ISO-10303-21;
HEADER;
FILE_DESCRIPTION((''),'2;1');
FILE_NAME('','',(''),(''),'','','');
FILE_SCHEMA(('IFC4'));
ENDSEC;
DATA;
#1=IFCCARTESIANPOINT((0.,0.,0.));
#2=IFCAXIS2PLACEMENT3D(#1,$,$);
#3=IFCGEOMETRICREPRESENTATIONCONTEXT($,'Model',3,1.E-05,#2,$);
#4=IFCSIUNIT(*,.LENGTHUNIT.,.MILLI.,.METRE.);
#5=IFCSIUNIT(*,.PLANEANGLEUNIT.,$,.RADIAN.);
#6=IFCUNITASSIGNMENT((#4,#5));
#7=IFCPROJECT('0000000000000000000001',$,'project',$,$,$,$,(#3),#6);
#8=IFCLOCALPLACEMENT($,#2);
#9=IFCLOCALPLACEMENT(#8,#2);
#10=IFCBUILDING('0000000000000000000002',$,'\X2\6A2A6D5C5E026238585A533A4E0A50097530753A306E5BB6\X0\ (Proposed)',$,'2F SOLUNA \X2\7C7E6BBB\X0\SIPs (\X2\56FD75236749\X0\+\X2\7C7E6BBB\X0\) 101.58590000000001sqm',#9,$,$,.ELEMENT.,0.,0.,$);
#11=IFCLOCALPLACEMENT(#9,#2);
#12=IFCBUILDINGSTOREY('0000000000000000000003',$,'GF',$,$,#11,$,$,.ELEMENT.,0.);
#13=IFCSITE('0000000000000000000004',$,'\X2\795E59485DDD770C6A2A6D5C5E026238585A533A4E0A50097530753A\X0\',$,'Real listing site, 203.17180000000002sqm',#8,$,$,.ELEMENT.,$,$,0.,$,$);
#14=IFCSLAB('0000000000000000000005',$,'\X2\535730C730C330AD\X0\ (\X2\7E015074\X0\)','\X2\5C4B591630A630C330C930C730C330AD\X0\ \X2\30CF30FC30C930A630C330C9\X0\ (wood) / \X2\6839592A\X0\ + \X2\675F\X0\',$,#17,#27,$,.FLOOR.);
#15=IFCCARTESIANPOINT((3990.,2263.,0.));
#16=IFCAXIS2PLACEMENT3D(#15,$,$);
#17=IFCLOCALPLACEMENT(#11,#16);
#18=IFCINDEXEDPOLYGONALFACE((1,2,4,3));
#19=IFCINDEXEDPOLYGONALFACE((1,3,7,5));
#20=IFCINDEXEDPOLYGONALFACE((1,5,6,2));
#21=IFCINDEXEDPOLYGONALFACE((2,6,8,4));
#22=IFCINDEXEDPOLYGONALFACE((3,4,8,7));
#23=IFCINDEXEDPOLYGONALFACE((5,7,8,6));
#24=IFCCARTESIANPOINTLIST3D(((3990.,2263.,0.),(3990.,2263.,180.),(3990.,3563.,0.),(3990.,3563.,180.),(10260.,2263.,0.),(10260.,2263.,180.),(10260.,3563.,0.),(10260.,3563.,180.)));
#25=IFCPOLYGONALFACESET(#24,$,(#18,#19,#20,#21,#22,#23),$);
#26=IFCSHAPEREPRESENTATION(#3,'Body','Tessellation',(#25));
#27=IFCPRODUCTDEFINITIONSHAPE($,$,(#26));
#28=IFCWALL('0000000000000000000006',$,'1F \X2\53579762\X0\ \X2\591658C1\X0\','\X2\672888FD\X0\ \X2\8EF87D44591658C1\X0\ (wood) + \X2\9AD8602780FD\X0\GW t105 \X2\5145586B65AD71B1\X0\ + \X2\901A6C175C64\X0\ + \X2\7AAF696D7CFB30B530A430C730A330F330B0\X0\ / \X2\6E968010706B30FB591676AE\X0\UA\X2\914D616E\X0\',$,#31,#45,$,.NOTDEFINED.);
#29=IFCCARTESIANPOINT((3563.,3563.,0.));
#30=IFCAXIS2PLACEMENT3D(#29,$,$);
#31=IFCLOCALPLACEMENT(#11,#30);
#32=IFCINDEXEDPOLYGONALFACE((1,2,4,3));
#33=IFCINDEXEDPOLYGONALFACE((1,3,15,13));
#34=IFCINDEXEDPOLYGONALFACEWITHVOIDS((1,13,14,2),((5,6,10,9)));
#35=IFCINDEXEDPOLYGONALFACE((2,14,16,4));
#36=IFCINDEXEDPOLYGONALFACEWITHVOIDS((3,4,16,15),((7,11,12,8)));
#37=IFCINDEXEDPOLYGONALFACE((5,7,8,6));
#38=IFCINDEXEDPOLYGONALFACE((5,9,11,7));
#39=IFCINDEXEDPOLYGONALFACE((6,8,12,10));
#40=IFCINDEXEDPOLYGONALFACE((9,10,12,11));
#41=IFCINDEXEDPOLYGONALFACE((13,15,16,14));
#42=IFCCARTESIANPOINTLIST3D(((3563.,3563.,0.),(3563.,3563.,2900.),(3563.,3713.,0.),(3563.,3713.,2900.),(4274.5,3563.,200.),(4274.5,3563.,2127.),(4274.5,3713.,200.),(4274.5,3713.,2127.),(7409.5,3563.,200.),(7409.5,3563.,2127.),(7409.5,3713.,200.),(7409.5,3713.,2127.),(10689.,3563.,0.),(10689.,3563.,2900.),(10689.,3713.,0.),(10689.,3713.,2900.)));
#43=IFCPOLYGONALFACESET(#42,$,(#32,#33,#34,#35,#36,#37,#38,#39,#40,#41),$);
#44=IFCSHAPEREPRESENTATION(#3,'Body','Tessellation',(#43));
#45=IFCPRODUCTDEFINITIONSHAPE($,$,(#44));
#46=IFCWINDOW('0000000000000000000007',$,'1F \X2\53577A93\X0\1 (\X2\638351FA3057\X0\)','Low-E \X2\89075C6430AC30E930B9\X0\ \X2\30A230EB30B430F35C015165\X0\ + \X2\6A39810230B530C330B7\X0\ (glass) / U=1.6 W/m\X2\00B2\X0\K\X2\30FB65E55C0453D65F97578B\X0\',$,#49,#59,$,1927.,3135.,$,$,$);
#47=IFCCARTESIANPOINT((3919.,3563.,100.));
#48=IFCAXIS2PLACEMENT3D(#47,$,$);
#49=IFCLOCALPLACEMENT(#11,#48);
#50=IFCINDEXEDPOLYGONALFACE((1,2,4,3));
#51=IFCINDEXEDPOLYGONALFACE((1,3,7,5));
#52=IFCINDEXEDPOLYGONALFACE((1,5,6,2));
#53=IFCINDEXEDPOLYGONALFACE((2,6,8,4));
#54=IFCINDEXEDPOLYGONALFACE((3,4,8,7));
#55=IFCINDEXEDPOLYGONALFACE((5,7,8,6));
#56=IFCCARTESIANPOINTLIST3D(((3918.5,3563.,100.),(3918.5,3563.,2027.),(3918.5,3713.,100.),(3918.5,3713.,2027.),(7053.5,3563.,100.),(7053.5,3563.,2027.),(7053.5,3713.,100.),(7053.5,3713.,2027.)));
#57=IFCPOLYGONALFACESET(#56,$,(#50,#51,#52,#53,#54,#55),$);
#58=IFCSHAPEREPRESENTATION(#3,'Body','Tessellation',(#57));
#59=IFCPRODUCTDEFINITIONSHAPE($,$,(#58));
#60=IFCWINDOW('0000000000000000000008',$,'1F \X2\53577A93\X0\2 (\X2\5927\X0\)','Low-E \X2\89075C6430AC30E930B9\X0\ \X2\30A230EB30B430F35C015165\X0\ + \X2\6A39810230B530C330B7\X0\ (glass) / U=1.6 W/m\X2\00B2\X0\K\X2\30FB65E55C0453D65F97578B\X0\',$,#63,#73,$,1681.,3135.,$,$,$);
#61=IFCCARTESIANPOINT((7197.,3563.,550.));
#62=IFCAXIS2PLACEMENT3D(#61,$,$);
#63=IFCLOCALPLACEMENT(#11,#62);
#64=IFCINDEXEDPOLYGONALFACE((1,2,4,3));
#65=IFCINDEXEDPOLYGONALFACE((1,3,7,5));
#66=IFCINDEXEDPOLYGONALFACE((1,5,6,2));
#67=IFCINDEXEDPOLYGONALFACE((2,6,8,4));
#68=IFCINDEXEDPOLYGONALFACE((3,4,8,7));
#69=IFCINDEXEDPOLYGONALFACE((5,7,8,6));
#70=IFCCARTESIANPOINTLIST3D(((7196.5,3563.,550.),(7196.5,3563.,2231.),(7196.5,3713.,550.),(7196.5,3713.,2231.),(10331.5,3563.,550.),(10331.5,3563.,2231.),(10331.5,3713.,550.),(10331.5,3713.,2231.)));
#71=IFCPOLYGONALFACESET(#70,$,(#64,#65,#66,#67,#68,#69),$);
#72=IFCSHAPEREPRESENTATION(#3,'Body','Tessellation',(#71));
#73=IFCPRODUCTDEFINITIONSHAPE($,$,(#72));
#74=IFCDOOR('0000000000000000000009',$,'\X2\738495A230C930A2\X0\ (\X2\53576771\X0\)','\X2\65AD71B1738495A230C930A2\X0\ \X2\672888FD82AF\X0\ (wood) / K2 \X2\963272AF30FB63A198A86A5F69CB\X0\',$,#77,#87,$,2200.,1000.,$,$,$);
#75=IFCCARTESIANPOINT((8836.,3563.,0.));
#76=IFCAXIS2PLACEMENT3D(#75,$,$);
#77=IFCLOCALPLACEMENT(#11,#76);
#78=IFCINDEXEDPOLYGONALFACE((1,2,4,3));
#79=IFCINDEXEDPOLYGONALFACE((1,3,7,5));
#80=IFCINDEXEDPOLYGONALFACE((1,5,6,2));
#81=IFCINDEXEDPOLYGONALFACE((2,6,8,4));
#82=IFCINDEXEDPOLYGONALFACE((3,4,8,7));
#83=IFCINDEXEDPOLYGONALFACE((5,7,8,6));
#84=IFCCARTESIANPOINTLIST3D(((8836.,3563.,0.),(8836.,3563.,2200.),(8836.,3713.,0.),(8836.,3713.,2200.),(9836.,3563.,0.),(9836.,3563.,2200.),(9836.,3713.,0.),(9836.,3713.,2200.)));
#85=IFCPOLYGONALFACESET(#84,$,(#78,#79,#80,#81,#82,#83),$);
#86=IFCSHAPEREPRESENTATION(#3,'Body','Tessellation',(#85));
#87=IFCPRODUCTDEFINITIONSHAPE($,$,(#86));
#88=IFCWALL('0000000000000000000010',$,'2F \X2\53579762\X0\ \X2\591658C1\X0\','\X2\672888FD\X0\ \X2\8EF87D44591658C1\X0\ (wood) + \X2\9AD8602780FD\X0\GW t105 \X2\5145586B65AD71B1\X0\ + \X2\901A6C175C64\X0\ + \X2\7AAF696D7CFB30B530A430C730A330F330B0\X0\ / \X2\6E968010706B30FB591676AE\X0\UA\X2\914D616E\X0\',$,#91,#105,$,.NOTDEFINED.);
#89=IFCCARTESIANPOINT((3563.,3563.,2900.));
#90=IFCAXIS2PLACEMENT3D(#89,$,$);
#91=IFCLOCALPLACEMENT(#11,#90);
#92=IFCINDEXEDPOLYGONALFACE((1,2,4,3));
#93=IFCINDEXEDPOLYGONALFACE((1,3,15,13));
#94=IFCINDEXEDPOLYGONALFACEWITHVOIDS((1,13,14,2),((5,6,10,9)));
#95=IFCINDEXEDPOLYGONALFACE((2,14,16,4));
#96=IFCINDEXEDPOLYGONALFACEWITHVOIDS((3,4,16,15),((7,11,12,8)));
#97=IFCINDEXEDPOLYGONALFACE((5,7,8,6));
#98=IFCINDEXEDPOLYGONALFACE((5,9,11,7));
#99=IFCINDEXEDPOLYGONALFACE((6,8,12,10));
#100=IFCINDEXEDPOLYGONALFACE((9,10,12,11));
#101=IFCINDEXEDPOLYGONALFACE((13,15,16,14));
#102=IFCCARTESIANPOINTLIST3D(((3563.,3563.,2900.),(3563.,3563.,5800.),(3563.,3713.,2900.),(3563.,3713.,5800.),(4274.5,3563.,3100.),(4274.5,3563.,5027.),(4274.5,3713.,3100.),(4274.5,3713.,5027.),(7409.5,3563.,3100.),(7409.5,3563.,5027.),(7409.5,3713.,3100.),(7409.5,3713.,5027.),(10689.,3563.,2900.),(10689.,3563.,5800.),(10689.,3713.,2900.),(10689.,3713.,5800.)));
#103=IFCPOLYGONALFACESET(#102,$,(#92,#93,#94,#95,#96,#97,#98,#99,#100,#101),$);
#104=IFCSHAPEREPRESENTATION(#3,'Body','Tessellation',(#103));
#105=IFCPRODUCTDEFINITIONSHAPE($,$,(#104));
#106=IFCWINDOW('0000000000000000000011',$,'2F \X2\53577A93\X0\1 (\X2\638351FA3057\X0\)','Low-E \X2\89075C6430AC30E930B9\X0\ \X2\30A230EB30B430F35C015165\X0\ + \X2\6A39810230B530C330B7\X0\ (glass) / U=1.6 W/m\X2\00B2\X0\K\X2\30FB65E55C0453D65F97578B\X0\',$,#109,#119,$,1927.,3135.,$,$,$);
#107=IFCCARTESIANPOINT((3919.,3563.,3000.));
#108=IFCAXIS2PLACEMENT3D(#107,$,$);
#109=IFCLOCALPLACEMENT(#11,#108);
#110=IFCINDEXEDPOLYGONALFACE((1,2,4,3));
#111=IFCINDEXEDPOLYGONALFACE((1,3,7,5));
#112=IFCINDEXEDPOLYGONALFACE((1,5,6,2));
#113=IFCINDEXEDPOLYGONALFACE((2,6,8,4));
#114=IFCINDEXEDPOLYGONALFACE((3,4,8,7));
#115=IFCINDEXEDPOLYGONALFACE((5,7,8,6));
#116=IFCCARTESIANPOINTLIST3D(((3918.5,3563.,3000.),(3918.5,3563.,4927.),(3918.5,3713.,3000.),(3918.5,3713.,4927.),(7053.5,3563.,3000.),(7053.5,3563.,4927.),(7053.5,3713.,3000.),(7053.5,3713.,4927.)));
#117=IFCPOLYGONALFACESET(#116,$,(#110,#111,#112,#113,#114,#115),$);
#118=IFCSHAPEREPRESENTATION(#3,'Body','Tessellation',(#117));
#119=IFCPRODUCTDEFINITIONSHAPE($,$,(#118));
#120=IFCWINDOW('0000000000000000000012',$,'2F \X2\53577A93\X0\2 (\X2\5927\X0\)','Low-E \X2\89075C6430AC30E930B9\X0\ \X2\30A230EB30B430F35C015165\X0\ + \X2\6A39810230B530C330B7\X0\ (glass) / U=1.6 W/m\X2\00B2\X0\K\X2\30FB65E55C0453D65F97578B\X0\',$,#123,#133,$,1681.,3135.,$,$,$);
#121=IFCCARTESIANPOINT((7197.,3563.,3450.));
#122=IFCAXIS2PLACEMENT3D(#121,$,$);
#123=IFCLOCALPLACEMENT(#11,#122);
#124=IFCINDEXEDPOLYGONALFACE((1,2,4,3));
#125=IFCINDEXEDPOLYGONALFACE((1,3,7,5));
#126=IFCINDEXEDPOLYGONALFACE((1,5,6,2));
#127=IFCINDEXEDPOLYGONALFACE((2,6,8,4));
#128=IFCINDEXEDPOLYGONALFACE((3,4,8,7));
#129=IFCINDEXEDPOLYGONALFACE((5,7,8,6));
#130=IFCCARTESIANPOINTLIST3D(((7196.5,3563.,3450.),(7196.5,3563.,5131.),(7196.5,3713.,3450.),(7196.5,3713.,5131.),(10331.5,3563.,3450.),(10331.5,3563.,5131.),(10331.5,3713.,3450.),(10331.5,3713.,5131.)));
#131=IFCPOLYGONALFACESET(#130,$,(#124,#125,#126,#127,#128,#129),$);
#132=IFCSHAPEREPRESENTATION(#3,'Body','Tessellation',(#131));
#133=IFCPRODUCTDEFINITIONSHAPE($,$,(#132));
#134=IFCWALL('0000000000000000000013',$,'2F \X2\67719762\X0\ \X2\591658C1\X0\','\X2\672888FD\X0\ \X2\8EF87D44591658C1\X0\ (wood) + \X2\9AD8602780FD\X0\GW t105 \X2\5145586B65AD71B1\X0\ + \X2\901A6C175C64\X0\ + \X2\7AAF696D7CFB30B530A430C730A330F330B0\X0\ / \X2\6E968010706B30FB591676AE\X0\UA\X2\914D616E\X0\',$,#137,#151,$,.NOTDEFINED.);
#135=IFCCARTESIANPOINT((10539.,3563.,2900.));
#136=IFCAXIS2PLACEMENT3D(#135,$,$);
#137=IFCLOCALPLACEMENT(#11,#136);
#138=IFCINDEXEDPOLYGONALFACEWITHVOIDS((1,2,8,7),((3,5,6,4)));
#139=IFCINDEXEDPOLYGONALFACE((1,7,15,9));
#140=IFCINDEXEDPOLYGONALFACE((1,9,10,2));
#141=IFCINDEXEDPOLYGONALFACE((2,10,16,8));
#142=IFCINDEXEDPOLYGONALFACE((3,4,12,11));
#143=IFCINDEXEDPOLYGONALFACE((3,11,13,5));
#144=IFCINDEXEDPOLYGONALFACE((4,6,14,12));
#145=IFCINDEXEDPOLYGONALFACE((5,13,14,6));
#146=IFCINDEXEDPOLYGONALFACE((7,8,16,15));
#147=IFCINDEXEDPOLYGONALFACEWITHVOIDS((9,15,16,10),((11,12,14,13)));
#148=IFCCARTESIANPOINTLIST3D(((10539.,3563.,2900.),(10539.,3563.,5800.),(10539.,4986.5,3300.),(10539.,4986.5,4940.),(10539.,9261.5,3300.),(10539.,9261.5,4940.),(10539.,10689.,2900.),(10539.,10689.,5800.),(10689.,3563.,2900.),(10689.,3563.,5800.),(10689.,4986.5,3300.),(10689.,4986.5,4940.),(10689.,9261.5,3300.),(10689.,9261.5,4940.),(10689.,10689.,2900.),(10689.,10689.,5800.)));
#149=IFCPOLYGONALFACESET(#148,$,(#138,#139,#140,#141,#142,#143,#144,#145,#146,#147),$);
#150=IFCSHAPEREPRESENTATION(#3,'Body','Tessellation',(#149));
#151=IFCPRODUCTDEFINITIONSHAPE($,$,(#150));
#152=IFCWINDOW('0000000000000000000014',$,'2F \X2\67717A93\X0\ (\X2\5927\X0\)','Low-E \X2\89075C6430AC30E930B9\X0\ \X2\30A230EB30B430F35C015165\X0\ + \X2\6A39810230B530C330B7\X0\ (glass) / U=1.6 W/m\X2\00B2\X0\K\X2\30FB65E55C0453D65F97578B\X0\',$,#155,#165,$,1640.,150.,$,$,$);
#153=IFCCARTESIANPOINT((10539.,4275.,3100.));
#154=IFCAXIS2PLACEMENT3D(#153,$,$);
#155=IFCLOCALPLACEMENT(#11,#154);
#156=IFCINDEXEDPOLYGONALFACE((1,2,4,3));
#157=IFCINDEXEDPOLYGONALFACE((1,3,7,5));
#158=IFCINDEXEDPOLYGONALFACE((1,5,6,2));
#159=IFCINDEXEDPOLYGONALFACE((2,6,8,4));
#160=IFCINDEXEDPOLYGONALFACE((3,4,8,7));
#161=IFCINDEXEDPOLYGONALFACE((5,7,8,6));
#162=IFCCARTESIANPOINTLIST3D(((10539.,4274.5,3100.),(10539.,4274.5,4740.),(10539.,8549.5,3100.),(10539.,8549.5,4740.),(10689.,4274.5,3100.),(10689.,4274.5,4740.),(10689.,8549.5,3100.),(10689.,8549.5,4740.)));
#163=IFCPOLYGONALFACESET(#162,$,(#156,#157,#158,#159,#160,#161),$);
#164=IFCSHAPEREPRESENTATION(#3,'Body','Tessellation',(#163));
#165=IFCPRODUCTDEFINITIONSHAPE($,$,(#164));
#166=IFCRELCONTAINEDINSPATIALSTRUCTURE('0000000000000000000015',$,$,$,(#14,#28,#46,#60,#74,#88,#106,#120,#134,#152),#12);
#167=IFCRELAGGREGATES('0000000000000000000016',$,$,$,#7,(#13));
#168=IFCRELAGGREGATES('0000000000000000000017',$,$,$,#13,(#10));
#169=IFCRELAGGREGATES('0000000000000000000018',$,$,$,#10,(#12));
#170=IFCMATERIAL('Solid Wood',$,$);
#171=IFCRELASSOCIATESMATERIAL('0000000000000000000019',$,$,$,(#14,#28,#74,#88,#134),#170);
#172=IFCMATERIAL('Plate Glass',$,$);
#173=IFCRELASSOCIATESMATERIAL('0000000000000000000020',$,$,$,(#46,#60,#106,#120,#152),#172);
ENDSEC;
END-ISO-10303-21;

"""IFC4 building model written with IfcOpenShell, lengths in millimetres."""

from ifc_helpers import new_model, si_unit, frame, frame_2d, origin, place, context, project, spatial, rectangle, extrude, material, element, fill, save


model = new_model("IFC4")

# Units and contexts
model_context = context("Model", 3, precision=1e-05, world=origin())
ifc_project = project(units=[si_unit("LENGTHUNIT", "METRE", prefix="MILLI"), si_unit("PLANEANGLEUNIT", "RADIAN")], contexts=[model_context])

# Site, building, storey
site_placement = place(None, origin())
site = spatial("IfcSite", under=ifc_project, at=site_placement, Name="神奈川県横浜市戸塚区上倉田町", ObjectType="Real listing site, 203.17180000000002sqm", CompositionType="ELEMENT", RefElevation=0.0)
building_placement = place(site_placement, origin())
building = spatial("IfcBuilding", under=site, at=building_placement, Name="横浜市戸塚区上倉田町の家 (Proposed)", ObjectType="2F SOLUNA 籾殻SIPs (国産杉+籾殻) 101.58590000000001sqm", CompositionType="ELEMENT", ElevationOfRefHeight=0.0, ElevationOfTerrain=0.0)
storey_placement = place(building_placement, origin())
storey = spatial("IfcBuildingStorey", under=building, at=storey_placement, Name="GF", CompositionType="ELEMENT", Elevation=0.0)

# Slab
ifc_material_1 = material(Name="Solid Wood")
slab_1_placement = place(storey_placement, frame((3990.0, 2263.0, 0.0)))
element("IfcSlab", 1, at=slab_1_placement, inside=storey, material=ifc_material_1, Name="南デッキ (縁側)", Description="屋外ウッドデッキ ハードウッド (wood) / 根太 + 束", PredefinedType="FLOOR", context=model_context, shape_type="SweptSolid", body=[
    extrude(rectangle(XDim=6270.0, YDim=1300.0, at=frame_2d((3135.0, 650.0))), frame((3990.0, 2263.0, 0.0)), (0.0, 0.0, 1.0), 180.0),
])

# Wall, openings, windows, door
wall_1_placement = place(storey_placement, frame((3563.0, 3563.0, 0.0)))
wall_1 = element("IfcWall", 2, at=wall_1_placement, inside=storey, material=ifc_material_1, Name="1F 南面 外壁", Description="木製 軸組外壁 (wood) + 高性能GW t105 充填断熱 + 通気層 + 窯業系サイディング / 準耐火・外皮UA配慮", PredefinedType="NOTDEFINED", context=model_context, shape_type="SweptSolid", body=[
    extrude(rectangle(XDim=7126.0, YDim=150.0, at=frame_2d((3563.0, 75.0))), frame((3563.0, 3563.0, 0.0)), (0.0, 0.0, 1.0), 2900.0),
])
opening_1_placement = place(storey_placement, frame((3919.0, 3563.0, 100.0)))
opening_1 = element("IfcOpeningElement", 3, at=opening_1_placement, cuts=wall_1, PredefinedType="NOTDEFINED", context=model_context, shape_type="SweptSolid", body=[
    extrude(rectangle(XDim=3135.0, YDim=150.0, at=frame_2d((1567.0, 75.0))), frame((3919.0, 3563.0, 100.0)), (0.0, 0.0, 1.0), 1927.0),
])
opening_2_placement = place(storey_placement, frame((7197.0, 3563.0, 550.0)))
opening_2 = element("IfcOpeningElement", 4, at=opening_2_placement, cuts=wall_1, PredefinedType="NOTDEFINED", context=model_context, shape_type="SweptSolid", body=[
    extrude(rectangle(XDim=3135.0, YDim=150.0, at=frame_2d((1567.0, 75.0))), frame((7197.0, 3563.0, 550.0)), (0.0, 0.0, 1.0), 1681.0),
])
opening_3_placement = place(storey_placement, frame((8836.0, 3563.0, 0.0)))
opening_3 = element("IfcOpeningElement", 5, at=opening_3_placement, cuts=wall_1, PredefinedType="NOTDEFINED", context=model_context, shape_type="SweptSolid", body=[
    extrude(rectangle(XDim=1000.0, YDim=150.0, at=frame_2d((500.0, 75.0))), frame((8836.0, 3563.0, 0.0)), (0.0, 0.0, 1.0), 2200.0),
])
ifc_material_2 = material(Name="Plate Glass")
window_1_placement = place(storey_placement, frame((3919.0, 3563.0, 100.0)))
window_1 = element("IfcWindow", 6, at=window_1_placement, inside=storey, material=ifc_material_2, Name="1F 南窓1 (掃出し)", Description="Low-E 複層ガラス アルゴン封入 + 樹脂サッシ (glass) / U=1.6 W/m²K・日射取得型", OverallHeight=1927.0, OverallWidth=3135.0, context=model_context, shape_type="SweptSolid", body=[
    extrude(rectangle(XDim=3135.0, YDim=150.0, at=frame_2d((1567.0, 75.0))), frame((3919.0, 3563.0, 100.0)), (0.0, 0.0, 1.0), 1927.0),
])
fill(opening_1, window_1)
window_2_placement = place(storey_placement, frame((7197.0, 3563.0, 550.0)))
window_2 = element("IfcWindow", 7, at=window_2_placement, inside=storey, material=ifc_material_2, Name="1F 南窓2 (大)", Description="Low-E 複層ガラス アルゴン封入 + 樹脂サッシ (glass) / U=1.6 W/m²K・日射取得型", OverallHeight=1681.0, OverallWidth=3135.0, context=model_context, shape_type="SweptSolid", body=[
    extrude(rectangle(XDim=3135.0, YDim=150.0, at=frame_2d((1567.0, 75.0))), frame((7197.0, 3563.0, 550.0)), (0.0, 0.0, 1.0), 1681.0),
])
fill(opening_2, window_2)
door_placement = place(storey_placement, frame((8836.0, 3563.0, 0.0)))
door = element("IfcDoor", 8, at=door_placement, inside=storey, material=ifc_material_1, Name="玄関ドア (南東)", Description="断熱玄関ドア 木製芯 (wood) / K2 防犯・採風機構", OverallHeight=2200.0, OverallWidth=1000.0, context=model_context, shape_type="SweptSolid", body=[
    extrude(rectangle(XDim=1000.0, YDim=150.0, at=frame_2d((500.0, 75.0))), frame((8836.0, 3563.0, 0.0)), (0.0, 0.0, 1.0), 2200.0),
])
fill(opening_3, door)

# Wall, openings, windows
wall_2_placement = place(storey_placement, frame((3563.0, 3563.0, 2900.0)))
wall_2 = element("IfcWall", 9, at=wall_2_placement, inside=storey, material=ifc_material_1, Name="2F 南面 外壁", Description="木製 軸組外壁 (wood) + 高性能GW t105 充填断熱 + 通気層 + 窯業系サイディング / 準耐火・外皮UA配慮", PredefinedType="NOTDEFINED", context=model_context, shape_type="SweptSolid", body=[
    extrude(rectangle(XDim=7126.0, YDim=150.0, at=frame_2d((3563.0, 75.0))), frame((3563.0, 3563.0, 2900.0)), (0.0, 0.0, 1.0), 2900.0),
])
opening_4_placement = place(storey_placement, frame((3919.0, 3563.0, 3000.0)))
opening_4 = element("IfcOpeningElement", 10, at=opening_4_placement, cuts=wall_2, PredefinedType="NOTDEFINED", context=model_context, shape_type="SweptSolid", body=[
    extrude(rectangle(XDim=3135.0, YDim=150.0, at=frame_2d((1567.0, 75.0))), frame((3919.0, 3563.0, 3000.0)), (0.0, 0.0, 1.0), 1927.0),
])
opening_5_placement = place(storey_placement, frame((7197.0, 3563.0, 3450.0)))
opening_5 = element("IfcOpeningElement", 11, at=opening_5_placement, cuts=wall_2, PredefinedType="NOTDEFINED", context=model_context, shape_type="SweptSolid", body=[
    extrude(rectangle(XDim=3135.0, YDim=150.0, at=frame_2d((1567.0, 75.0))), frame((7197.0, 3563.0, 3450.0)), (0.0, 0.0, 1.0), 1681.0),
])
window_3_placement = place(storey_placement, frame((3919.0, 3563.0, 3000.0)))
window_3 = element("IfcWindow", 12, at=window_3_placement, inside=storey, material=ifc_material_2, Name="2F 南窓1 (掃出し)", Description="Low-E 複層ガラス アルゴン封入 + 樹脂サッシ (glass) / U=1.6 W/m²K・日射取得型", OverallHeight=1927.0, OverallWidth=3135.0, context=model_context, shape_type="SweptSolid", body=[
    extrude(rectangle(XDim=3135.0, YDim=150.0, at=frame_2d((1567.0, 75.0))), frame((3919.0, 3563.0, 3000.0)), (0.0, 0.0, 1.0), 1927.0),
])
fill(opening_4, window_3)
window_4_placement = place(storey_placement, frame((7197.0, 3563.0, 3450.0)))
window_4 = element("IfcWindow", 13, at=window_4_placement, inside=storey, material=ifc_material_2, Name="2F 南窓2 (大)", Description="Low-E 複層ガラス アルゴン封入 + 樹脂サッシ (glass) / U=1.6 W/m²K・日射取得型", OverallHeight=1681.0, OverallWidth=3135.0, context=model_context, shape_type="SweptSolid", body=[
    extrude(rectangle(XDim=3135.0, YDim=150.0, at=frame_2d((1567.0, 75.0))), frame((7197.0, 3563.0, 3450.0)), (0.0, 0.0, 1.0), 1681.0),
])
fill(opening_5, window_4)

# Wall, opening, window
wall_3_placement = place(storey_placement, frame((10539.0, 3563.0, 2900.0)))
wall_3 = element("IfcWall", 14, at=wall_3_placement, inside=storey, material=ifc_material_1, Name="2F 東面 外壁", Description="木製 軸組外壁 (wood) + 高性能GW t105 充填断熱 + 通気層 + 窯業系サイディング / 準耐火・外皮UA配慮", PredefinedType="NOTDEFINED", context=model_context, shape_type="SweptSolid", body=[
    extrude(rectangle(XDim=150.0, YDim=7126.0, at=frame_2d((75.0, 3563.0))), frame((10539.0, 3563.0, 2900.0)), (0.0, 0.0, 1.0), 2900.0),
])
opening_6_placement = place(storey_placement, frame((10539.0, 4275.0, 3100.0)))
opening_6 = element("IfcOpeningElement", 15, at=opening_6_placement, cuts=wall_3, PredefinedType="NOTDEFINED", context=model_context, shape_type="SweptSolid", body=[
    extrude(rectangle(XDim=150.0, YDim=4275.0, at=frame_2d((75.0, 2137.0))), frame((10539.0, 4275.0, 3100.0)), (0.0, 0.0, 1.0), 1640.0),
])
window_5_placement = place(storey_placement, frame((10539.0, 4275.0, 3100.0)))
window_5 = element("IfcWindow", 16, at=window_5_placement, inside=storey, material=ifc_material_2, Name="2F 東窓 (大)", Description="Low-E 複層ガラス アルゴン封入 + 樹脂サッシ (glass) / U=1.6 W/m²K・日射取得型", OverallHeight=1640.0, OverallWidth=150.0, context=model_context, shape_type="SweptSolid", body=[
    extrude(rectangle(XDim=150.0, YDim=4275.0, at=frame_2d((75.0, 2137.0))), frame((10539.0, 4275.0, 3100.0)), (0.0, 0.0, 1.0), 1640.0),
])
fill(opening_6, window_5)

save(model, "model.ifc")
